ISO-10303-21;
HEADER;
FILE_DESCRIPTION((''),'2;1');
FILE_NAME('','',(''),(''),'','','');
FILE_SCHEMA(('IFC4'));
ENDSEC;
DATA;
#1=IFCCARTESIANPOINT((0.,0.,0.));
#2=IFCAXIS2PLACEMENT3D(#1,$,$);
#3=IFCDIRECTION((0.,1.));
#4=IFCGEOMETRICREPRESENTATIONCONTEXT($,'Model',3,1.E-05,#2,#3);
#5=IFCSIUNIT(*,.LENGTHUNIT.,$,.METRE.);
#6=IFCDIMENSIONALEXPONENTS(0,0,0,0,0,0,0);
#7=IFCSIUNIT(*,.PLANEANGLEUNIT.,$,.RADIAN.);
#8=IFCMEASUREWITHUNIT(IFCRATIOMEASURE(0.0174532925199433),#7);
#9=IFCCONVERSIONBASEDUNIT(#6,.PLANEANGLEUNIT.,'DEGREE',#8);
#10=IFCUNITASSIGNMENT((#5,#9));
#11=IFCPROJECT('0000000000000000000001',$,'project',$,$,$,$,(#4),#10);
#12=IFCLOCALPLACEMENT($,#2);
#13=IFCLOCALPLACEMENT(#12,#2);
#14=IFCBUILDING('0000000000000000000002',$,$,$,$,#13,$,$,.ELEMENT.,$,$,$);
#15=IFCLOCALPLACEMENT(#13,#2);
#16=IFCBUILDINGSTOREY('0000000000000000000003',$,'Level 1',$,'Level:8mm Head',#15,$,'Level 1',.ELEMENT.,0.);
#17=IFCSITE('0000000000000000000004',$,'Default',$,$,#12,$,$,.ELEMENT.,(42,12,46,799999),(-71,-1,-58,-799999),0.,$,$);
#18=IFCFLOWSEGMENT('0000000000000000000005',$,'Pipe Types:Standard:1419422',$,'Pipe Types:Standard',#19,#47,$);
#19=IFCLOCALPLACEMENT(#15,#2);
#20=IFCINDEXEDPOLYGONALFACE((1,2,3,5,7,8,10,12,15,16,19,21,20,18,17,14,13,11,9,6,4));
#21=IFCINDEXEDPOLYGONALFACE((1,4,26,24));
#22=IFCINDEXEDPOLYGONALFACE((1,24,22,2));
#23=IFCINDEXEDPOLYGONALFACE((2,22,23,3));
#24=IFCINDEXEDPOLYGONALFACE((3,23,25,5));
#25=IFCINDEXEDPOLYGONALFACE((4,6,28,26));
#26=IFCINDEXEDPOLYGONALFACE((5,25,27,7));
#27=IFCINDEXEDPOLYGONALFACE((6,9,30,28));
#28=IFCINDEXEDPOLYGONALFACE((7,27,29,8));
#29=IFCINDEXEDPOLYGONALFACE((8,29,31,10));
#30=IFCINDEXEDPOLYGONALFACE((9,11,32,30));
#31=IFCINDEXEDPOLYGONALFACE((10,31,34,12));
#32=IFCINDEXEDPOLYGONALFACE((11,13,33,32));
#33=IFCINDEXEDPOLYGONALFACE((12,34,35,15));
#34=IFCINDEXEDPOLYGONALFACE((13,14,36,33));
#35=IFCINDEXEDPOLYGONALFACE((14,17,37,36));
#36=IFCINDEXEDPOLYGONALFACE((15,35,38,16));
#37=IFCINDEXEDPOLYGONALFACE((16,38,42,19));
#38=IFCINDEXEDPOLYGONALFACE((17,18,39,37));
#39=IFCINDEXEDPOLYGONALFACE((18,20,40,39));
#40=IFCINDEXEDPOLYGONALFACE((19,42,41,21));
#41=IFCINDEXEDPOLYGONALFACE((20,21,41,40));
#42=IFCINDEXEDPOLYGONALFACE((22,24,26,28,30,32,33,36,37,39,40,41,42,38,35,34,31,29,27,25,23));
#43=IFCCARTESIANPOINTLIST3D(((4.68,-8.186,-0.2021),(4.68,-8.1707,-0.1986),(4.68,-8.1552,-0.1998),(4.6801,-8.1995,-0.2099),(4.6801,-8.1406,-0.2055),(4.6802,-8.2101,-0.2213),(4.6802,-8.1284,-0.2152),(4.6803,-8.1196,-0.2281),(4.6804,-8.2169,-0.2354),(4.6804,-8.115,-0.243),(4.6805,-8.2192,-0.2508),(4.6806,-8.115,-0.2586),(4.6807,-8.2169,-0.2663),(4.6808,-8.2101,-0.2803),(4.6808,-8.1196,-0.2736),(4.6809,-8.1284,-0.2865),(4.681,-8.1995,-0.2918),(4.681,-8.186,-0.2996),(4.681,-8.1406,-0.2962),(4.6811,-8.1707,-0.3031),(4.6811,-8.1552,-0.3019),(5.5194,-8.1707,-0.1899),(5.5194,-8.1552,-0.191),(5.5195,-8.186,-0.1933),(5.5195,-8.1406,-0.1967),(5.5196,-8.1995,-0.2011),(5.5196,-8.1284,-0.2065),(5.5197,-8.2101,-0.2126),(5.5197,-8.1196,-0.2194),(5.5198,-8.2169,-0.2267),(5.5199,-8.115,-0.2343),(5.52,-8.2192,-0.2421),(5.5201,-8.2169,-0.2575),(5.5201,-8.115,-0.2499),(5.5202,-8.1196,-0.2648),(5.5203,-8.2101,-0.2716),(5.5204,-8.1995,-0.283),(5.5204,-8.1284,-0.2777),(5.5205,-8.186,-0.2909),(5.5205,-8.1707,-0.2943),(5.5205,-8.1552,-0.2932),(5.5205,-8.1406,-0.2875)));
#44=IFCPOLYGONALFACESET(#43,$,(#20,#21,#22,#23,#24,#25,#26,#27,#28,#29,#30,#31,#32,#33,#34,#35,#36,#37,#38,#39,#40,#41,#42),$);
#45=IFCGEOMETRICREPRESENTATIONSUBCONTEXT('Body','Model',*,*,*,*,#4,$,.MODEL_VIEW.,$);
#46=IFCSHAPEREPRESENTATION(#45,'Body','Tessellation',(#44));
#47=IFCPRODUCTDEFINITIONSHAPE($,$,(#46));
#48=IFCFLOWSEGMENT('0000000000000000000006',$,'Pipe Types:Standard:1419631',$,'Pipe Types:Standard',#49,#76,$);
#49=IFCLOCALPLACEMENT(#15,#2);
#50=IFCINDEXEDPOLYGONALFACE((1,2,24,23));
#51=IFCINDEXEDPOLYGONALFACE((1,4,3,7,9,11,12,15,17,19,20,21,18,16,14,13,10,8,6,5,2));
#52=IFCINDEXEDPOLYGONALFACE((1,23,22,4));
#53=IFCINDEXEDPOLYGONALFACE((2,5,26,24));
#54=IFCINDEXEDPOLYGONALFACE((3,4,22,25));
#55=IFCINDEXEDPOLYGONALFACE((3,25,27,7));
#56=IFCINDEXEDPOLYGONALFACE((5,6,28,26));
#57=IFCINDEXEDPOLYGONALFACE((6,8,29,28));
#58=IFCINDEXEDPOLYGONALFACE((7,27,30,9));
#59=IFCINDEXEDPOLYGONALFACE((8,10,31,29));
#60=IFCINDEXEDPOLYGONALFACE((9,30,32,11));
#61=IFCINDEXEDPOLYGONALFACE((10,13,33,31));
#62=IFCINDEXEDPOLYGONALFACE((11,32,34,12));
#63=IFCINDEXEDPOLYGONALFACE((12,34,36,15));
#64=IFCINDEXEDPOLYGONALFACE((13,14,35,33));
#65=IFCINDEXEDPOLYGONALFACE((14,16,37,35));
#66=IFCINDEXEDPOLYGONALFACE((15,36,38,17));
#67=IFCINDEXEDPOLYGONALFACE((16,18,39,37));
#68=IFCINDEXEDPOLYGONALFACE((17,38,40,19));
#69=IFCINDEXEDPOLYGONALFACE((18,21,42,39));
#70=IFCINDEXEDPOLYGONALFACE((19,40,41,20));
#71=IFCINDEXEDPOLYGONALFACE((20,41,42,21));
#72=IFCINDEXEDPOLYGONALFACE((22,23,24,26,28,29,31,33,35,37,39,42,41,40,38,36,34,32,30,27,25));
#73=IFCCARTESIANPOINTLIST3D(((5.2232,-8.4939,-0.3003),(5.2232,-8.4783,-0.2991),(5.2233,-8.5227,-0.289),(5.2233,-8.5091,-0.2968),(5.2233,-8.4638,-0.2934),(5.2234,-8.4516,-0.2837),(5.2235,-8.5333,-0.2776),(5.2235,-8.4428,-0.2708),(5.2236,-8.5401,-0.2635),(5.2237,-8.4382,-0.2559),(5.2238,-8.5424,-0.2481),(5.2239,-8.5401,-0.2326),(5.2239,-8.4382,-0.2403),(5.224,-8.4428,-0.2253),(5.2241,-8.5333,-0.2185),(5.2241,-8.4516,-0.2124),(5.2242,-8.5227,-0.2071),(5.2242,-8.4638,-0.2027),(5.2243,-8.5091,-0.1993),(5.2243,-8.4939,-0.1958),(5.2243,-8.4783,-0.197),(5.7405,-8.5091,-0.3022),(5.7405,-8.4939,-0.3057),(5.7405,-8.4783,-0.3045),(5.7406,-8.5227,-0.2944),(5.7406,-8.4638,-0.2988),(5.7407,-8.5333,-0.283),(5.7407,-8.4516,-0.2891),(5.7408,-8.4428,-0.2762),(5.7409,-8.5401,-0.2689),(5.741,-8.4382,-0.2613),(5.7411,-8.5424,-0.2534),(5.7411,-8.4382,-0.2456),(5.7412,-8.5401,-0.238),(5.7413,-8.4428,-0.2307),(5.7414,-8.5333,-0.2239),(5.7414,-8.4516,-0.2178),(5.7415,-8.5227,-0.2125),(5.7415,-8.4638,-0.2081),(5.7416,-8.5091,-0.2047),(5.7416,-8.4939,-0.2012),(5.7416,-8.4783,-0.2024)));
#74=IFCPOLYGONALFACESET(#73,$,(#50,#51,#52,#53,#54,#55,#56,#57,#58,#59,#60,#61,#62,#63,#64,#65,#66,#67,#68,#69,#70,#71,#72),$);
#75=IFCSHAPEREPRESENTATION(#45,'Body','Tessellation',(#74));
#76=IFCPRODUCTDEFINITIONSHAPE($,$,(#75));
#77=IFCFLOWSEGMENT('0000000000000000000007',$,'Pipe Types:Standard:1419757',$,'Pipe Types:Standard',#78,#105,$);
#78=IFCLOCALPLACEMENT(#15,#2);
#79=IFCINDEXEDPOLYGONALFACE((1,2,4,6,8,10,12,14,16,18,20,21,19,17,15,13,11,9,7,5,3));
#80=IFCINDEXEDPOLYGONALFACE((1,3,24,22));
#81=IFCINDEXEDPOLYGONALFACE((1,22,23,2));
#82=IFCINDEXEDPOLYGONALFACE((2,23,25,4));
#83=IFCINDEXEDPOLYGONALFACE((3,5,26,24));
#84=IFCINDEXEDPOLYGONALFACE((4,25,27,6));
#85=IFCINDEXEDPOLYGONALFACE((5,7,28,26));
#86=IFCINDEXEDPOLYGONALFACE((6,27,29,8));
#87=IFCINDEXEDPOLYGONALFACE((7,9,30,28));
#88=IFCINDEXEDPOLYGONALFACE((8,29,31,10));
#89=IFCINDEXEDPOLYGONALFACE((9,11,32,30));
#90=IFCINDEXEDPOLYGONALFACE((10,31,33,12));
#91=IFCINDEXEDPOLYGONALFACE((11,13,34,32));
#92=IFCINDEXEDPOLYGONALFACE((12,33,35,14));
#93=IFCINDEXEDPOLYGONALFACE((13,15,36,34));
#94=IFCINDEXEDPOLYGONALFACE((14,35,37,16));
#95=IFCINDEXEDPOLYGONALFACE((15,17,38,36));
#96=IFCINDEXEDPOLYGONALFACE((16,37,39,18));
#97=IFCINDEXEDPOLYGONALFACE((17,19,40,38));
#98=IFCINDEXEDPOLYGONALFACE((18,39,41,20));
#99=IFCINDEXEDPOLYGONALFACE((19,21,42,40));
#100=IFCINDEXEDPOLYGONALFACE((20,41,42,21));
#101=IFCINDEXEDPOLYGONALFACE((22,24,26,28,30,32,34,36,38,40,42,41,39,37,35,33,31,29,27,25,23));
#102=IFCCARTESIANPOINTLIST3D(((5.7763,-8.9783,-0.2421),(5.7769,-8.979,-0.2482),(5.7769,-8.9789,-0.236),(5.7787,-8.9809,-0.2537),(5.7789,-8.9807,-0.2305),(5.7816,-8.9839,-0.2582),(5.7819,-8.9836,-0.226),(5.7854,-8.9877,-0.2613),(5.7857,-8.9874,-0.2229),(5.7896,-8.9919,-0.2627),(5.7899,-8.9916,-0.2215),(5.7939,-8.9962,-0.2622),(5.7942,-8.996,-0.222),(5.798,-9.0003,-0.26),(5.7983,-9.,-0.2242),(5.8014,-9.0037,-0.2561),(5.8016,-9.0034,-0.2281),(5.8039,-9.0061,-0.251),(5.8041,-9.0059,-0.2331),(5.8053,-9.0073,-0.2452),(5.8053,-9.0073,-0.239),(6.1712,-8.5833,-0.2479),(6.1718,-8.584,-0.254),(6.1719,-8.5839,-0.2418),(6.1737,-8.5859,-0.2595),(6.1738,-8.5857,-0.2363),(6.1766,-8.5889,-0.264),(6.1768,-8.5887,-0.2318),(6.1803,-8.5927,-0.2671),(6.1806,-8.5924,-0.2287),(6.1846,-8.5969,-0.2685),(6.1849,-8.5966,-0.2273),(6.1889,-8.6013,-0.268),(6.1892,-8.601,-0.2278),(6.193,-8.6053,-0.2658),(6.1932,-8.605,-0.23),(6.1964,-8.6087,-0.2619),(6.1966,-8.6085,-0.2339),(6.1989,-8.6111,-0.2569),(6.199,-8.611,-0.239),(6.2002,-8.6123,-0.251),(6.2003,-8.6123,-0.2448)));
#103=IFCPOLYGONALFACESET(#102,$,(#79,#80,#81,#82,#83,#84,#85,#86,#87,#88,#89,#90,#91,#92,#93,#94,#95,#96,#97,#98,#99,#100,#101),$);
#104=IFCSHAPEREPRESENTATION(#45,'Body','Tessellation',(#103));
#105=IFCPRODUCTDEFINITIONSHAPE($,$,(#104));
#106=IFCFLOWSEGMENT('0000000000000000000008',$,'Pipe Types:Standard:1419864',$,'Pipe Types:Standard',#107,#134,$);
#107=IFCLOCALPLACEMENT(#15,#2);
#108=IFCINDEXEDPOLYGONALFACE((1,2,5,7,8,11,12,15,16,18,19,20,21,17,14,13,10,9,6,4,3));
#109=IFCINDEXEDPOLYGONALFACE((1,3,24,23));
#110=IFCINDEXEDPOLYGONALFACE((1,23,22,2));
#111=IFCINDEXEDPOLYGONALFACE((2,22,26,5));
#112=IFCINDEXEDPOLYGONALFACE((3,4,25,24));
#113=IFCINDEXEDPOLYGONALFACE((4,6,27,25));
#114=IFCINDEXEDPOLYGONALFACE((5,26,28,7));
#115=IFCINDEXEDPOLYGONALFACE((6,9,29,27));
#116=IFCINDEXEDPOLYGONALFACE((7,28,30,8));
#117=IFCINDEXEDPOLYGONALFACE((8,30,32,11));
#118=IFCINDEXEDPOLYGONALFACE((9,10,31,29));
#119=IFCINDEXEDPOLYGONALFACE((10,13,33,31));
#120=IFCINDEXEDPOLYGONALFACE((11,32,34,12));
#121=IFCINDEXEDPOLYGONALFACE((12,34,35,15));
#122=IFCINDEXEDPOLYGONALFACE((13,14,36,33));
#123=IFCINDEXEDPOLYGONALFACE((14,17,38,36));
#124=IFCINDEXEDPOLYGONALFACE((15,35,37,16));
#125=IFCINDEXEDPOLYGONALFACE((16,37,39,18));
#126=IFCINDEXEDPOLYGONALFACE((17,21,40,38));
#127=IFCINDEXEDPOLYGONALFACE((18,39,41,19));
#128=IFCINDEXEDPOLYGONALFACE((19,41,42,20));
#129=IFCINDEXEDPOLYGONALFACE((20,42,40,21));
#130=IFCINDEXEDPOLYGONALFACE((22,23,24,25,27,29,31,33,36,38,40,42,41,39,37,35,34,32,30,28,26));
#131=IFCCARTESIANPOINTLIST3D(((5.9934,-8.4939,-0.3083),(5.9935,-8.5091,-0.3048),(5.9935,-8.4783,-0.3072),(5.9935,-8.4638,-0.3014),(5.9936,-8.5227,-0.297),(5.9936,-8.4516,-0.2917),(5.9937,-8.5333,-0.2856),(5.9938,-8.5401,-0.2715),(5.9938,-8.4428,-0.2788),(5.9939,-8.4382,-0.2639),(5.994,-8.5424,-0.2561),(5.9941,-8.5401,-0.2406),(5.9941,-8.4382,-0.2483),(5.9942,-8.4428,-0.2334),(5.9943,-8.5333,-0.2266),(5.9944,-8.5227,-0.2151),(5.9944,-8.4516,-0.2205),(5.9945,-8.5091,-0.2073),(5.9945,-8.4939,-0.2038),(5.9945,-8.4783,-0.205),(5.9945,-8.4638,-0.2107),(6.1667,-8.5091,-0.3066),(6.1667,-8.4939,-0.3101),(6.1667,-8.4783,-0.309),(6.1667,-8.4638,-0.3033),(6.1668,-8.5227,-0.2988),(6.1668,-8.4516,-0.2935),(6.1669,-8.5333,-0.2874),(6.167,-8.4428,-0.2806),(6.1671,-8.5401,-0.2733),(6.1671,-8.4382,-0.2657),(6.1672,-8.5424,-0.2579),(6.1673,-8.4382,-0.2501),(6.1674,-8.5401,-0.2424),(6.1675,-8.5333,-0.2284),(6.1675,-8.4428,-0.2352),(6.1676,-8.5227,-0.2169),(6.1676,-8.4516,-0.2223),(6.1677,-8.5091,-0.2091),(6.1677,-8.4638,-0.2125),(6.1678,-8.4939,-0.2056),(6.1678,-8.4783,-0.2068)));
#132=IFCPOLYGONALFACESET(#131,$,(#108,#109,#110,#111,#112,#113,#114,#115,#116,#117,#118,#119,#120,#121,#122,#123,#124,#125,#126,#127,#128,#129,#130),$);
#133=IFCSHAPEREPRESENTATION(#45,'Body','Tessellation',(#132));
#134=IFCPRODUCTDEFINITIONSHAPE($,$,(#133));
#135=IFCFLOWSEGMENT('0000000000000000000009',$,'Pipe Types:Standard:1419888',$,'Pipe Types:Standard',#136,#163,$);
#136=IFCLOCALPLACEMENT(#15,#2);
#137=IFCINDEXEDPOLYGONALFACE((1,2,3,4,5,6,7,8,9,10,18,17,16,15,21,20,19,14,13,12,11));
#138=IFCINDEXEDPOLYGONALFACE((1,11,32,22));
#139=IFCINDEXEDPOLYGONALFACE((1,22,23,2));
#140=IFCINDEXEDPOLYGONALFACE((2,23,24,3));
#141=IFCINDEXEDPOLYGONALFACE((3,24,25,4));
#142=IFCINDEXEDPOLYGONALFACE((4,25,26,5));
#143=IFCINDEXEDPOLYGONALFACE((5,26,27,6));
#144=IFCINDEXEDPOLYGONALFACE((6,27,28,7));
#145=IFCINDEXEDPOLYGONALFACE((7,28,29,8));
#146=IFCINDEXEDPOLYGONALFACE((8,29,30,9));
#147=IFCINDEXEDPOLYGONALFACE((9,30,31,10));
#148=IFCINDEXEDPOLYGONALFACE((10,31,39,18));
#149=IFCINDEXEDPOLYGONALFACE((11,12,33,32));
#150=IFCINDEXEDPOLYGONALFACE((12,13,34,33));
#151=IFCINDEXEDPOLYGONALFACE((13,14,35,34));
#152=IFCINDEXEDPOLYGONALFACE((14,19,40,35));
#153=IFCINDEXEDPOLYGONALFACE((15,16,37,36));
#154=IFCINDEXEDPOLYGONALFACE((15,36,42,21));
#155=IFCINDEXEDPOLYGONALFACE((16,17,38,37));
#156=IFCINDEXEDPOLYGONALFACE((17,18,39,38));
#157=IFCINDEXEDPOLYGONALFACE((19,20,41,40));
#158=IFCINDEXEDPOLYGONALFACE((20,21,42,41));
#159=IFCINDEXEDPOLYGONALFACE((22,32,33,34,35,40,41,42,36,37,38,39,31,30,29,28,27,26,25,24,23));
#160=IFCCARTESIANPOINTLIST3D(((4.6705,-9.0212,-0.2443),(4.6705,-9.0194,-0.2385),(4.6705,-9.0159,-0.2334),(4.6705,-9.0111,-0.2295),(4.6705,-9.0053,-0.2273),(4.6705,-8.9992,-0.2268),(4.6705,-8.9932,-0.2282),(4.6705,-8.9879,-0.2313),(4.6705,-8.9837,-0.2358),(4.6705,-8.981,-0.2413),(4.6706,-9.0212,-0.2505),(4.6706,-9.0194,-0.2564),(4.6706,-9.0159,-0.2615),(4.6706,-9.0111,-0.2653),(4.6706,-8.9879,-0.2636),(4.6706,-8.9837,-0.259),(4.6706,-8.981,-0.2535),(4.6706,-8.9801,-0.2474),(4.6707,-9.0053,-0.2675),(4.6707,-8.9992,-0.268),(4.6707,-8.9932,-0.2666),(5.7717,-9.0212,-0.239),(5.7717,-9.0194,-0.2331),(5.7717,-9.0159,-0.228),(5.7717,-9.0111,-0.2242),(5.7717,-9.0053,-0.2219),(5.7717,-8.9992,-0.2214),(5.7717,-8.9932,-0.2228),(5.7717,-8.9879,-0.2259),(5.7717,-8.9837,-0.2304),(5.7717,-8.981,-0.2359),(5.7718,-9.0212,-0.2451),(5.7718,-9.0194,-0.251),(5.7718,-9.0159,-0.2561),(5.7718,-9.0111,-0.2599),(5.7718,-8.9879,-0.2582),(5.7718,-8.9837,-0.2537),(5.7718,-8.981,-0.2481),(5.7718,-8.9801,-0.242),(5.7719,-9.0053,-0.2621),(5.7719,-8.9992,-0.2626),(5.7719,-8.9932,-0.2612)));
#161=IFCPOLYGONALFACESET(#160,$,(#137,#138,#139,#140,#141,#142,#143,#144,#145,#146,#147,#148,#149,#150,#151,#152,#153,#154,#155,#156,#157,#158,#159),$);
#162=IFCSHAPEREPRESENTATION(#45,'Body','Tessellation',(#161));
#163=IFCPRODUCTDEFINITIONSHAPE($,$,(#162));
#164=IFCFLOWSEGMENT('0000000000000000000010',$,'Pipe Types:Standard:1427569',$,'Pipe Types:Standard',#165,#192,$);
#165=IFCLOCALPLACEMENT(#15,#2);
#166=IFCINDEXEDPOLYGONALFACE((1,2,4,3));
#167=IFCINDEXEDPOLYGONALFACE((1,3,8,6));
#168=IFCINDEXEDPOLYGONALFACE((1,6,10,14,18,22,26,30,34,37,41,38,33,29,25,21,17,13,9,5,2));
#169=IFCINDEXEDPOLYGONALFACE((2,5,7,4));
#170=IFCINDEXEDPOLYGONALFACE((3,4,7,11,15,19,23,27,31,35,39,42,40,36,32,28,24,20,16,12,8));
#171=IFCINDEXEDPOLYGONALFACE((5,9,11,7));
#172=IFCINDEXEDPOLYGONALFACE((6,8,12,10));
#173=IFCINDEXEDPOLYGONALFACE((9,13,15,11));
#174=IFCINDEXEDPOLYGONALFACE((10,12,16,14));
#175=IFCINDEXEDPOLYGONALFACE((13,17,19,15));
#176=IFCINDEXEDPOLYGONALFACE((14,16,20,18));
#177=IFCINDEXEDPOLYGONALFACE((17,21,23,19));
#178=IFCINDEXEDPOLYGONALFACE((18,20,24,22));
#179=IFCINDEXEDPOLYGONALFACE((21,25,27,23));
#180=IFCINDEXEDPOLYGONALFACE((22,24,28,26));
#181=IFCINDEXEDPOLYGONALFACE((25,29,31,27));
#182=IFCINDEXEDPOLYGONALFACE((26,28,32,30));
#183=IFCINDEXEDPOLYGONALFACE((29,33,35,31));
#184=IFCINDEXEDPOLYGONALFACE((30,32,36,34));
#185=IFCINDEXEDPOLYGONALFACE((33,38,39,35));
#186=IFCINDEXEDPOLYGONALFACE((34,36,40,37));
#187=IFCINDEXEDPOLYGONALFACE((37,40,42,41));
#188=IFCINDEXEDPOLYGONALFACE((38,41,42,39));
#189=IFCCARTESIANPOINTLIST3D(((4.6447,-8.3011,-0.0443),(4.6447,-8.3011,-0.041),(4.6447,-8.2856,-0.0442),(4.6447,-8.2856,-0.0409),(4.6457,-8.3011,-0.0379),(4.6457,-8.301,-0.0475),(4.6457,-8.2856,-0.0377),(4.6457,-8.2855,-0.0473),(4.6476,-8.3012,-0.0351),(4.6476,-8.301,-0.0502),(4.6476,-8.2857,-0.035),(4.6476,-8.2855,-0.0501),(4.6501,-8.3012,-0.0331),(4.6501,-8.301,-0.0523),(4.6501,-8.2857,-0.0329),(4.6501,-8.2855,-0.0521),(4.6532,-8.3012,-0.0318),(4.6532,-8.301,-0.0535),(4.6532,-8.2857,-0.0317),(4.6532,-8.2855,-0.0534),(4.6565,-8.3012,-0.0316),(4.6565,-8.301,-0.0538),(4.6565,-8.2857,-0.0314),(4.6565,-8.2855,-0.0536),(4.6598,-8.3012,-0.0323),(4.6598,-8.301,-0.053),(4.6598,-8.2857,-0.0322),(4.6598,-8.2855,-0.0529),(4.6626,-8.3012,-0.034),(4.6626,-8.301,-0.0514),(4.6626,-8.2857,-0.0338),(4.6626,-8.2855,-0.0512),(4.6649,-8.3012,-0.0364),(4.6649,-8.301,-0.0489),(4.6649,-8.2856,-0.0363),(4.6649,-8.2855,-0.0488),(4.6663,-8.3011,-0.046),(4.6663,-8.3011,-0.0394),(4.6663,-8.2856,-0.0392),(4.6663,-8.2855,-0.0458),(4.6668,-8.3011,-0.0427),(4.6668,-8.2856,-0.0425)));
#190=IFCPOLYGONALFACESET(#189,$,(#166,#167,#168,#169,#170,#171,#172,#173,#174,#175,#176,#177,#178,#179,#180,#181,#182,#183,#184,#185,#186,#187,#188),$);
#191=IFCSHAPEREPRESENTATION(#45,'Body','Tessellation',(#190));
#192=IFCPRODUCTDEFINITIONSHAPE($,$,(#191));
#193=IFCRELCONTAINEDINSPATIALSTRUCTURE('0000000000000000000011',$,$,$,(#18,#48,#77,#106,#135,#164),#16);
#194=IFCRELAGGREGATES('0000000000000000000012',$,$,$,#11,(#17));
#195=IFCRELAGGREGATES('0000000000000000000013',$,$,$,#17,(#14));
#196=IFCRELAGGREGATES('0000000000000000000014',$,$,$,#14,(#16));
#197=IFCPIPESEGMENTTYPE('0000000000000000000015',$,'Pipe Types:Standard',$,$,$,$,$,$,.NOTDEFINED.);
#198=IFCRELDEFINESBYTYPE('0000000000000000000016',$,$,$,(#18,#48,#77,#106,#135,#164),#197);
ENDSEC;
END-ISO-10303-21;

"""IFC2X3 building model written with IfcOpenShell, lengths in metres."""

from ifc_helpers import new_model, entity, si_unit, converted_unit, direction, frame, frame_2d, origin, origin_2d_with_axis, place, context, subcontext, project, spatial, circle, extrude, type_object, element, save


model = new_model("IFC2X3")

# Units and contexts
model_context = context("Model", 3, precision=1e-05, world=origin(), true_north=direction((0.0, 1.0)))
body_context = subcontext(model_context, "Body", "Model", "MODEL_VIEW")
ifc_project = project(units=[si_unit("LENGTHUNIT", "METRE"), converted_unit("PLANEANGLEUNIT", "DEGREE", entity("IfcRatioMeasure", 0.0174532925199433), si_unit("PLANEANGLEUNIT", "RADIAN"), dimensions=[0, 0, 0, 0, 0, 0, 0])], contexts=[model_context])

# Site, building, storey
site_placement = place(None, origin())
site = spatial("IfcSite", under=ifc_project, at=site_placement, Name="Default", CompositionType="ELEMENT", RefLatitude=(42, 12, 46, 799999), RefLongitude=(-71, -1, -58, -799999), RefElevation=0.0)
building_placement = place(site_placement, origin())
building = spatial("IfcBuilding", under=site, at=building_placement, CompositionType="ELEMENT")
storey_placement = place(building_placement, origin())
storey = spatial("IfcBuildingStorey", under=building, at=storey_placement, Name="Level 1", ObjectType="Level:8mm Head", LongName="Level 1", CompositionType="ELEMENT", Elevation=0.0)

# Flow segments
pipe_segment_type = type_object("IfcPipeSegmentType", Name="Pipe Types:Standard", PredefinedType="NOTDEFINED")
flow_segment_1_placement = place(storey_placement, origin())
element("IfcFlowSegment", 1, at=flow_segment_1_placement, inside=storey, type_object=pipe_segment_type, Name="Pipe Types:Standard:1419422", ObjectType="Pipe Types:Standard", context=body_context, shape_type="SweptSolid", body=[
    extrude(circle(Radius=0.0524, at=frame_2d((0.0, 0.0), x_axis=(1.0, 0.0))), frame((4.6805, -8.1668, -0.2508), z_axis=(0.999946, 0.0, 0.010416), x_axis=(0.0, -1.0, 0.0)), (0.0, 0.0, 1.0), 0.8395),
])
flow_segment_2_placement = place(storey_placement, origin())
element("IfcFlowSegment", 2, at=flow_segment_2_placement, inside=storey, type_object=pipe_segment_type, Name="Pipe Types:Standard:1419631", ObjectType="Pipe Types:Standard", context=body_context, shape_type="SweptSolid", body=[
    extrude(circle(Radius=0.0524, at=frame_2d((0.0, 0.0), x_axis=(1.0, 0.0))), frame((5.7411, -8.49, -0.2534), z_axis=(-0.999946, 0.0, 0.010416), x_axis=(0.0, -1.0, 0.0)), (0.0, 0.0, 1.0), 0.5173),
])
flow_segment_3_placement = place(storey_placement, origin())
element("IfcFlowSegment", 3, at=flow_segment_3_placement, inside=storey, type_object=pipe_segment_type, Name="Pipe Types:Standard:1419757", ObjectType="Pipe Types:Standard", context=body_context, shape_type="SweptSolid", body=[
    extrude(circle(Radius=0.0206, at=frame_2d((0.0, 0.0), x_axis=(1.0, 0.0))), frame((6.1858, -8.5979, -0.2479), z_axis=(-0.707068, -0.707068, 0.010416), x_axis=(-0.707107, 0.707107, 0.0)), (0.0, 0.0, 1.0), 0.5586),
])
flow_segment_4_placement = place(storey_placement, origin())
element("IfcFlowSegment", 4, at=flow_segment_4_placement, inside=storey, type_object=pipe_segment_type, Name="Pipe Types:Standard:1419864", ObjectType="Pipe Types:Standard", context=body_context, shape_type="SweptSolid", body=[
    extrude(circle(Radius=0.0524, at=frame_2d((0.0, 0.0), x_axis=(1.0, 0.0))), frame((6.1672, -8.49, -0.2579), z_axis=(-0.999946, 0.0, 0.010416), x_axis=(0.0, -1.0, 0.0)), (0.0, 0.0, 1.0), 0.1732),
])
flow_segment_5_placement = place(storey_placement, origin())
element("IfcFlowSegment", 5, at=flow_segment_5_placement, inside=storey, type_object=pipe_segment_type, Name="Pipe Types:Standard:1419888", ObjectType="Pipe Types:Standard", context=body_context, shape_type="SweptSolid", body=[
    extrude(circle(Radius=0.0206, at=origin_2d_with_axis()), frame((4.6706, -9.0008, -0.2474), z_axis=(0.999988, 0.0, 0.004897), x_axis=(0.0, 1.0, 0.0)), (0.0, 0.0, 1.0), 1.1012),
])
flow_segment_6_placement = place(storey_placement, origin())
element("IfcFlowSegment", 6, at=flow_segment_6_placement, inside=storey, type_object=pipe_segment_type, Name="Pipe Types:Standard:1427569", ObjectType="Pipe Types:Standard", context=body_context, shape_type="SweptSolid", body=[
    extrude(circle(Radius=0.0111, at=frame_2d((0.0, 0.0), x_axis=(1.0, 0.0))), frame((4.6557, -8.3011, -0.0427), z_axis=(0.0, 0.999946, 0.010416), x_axis=(1.0, 0.0, 0.0)), (0.0, 0.0, 1.0), 0.0155),
])

save(model, "model.ifc")
